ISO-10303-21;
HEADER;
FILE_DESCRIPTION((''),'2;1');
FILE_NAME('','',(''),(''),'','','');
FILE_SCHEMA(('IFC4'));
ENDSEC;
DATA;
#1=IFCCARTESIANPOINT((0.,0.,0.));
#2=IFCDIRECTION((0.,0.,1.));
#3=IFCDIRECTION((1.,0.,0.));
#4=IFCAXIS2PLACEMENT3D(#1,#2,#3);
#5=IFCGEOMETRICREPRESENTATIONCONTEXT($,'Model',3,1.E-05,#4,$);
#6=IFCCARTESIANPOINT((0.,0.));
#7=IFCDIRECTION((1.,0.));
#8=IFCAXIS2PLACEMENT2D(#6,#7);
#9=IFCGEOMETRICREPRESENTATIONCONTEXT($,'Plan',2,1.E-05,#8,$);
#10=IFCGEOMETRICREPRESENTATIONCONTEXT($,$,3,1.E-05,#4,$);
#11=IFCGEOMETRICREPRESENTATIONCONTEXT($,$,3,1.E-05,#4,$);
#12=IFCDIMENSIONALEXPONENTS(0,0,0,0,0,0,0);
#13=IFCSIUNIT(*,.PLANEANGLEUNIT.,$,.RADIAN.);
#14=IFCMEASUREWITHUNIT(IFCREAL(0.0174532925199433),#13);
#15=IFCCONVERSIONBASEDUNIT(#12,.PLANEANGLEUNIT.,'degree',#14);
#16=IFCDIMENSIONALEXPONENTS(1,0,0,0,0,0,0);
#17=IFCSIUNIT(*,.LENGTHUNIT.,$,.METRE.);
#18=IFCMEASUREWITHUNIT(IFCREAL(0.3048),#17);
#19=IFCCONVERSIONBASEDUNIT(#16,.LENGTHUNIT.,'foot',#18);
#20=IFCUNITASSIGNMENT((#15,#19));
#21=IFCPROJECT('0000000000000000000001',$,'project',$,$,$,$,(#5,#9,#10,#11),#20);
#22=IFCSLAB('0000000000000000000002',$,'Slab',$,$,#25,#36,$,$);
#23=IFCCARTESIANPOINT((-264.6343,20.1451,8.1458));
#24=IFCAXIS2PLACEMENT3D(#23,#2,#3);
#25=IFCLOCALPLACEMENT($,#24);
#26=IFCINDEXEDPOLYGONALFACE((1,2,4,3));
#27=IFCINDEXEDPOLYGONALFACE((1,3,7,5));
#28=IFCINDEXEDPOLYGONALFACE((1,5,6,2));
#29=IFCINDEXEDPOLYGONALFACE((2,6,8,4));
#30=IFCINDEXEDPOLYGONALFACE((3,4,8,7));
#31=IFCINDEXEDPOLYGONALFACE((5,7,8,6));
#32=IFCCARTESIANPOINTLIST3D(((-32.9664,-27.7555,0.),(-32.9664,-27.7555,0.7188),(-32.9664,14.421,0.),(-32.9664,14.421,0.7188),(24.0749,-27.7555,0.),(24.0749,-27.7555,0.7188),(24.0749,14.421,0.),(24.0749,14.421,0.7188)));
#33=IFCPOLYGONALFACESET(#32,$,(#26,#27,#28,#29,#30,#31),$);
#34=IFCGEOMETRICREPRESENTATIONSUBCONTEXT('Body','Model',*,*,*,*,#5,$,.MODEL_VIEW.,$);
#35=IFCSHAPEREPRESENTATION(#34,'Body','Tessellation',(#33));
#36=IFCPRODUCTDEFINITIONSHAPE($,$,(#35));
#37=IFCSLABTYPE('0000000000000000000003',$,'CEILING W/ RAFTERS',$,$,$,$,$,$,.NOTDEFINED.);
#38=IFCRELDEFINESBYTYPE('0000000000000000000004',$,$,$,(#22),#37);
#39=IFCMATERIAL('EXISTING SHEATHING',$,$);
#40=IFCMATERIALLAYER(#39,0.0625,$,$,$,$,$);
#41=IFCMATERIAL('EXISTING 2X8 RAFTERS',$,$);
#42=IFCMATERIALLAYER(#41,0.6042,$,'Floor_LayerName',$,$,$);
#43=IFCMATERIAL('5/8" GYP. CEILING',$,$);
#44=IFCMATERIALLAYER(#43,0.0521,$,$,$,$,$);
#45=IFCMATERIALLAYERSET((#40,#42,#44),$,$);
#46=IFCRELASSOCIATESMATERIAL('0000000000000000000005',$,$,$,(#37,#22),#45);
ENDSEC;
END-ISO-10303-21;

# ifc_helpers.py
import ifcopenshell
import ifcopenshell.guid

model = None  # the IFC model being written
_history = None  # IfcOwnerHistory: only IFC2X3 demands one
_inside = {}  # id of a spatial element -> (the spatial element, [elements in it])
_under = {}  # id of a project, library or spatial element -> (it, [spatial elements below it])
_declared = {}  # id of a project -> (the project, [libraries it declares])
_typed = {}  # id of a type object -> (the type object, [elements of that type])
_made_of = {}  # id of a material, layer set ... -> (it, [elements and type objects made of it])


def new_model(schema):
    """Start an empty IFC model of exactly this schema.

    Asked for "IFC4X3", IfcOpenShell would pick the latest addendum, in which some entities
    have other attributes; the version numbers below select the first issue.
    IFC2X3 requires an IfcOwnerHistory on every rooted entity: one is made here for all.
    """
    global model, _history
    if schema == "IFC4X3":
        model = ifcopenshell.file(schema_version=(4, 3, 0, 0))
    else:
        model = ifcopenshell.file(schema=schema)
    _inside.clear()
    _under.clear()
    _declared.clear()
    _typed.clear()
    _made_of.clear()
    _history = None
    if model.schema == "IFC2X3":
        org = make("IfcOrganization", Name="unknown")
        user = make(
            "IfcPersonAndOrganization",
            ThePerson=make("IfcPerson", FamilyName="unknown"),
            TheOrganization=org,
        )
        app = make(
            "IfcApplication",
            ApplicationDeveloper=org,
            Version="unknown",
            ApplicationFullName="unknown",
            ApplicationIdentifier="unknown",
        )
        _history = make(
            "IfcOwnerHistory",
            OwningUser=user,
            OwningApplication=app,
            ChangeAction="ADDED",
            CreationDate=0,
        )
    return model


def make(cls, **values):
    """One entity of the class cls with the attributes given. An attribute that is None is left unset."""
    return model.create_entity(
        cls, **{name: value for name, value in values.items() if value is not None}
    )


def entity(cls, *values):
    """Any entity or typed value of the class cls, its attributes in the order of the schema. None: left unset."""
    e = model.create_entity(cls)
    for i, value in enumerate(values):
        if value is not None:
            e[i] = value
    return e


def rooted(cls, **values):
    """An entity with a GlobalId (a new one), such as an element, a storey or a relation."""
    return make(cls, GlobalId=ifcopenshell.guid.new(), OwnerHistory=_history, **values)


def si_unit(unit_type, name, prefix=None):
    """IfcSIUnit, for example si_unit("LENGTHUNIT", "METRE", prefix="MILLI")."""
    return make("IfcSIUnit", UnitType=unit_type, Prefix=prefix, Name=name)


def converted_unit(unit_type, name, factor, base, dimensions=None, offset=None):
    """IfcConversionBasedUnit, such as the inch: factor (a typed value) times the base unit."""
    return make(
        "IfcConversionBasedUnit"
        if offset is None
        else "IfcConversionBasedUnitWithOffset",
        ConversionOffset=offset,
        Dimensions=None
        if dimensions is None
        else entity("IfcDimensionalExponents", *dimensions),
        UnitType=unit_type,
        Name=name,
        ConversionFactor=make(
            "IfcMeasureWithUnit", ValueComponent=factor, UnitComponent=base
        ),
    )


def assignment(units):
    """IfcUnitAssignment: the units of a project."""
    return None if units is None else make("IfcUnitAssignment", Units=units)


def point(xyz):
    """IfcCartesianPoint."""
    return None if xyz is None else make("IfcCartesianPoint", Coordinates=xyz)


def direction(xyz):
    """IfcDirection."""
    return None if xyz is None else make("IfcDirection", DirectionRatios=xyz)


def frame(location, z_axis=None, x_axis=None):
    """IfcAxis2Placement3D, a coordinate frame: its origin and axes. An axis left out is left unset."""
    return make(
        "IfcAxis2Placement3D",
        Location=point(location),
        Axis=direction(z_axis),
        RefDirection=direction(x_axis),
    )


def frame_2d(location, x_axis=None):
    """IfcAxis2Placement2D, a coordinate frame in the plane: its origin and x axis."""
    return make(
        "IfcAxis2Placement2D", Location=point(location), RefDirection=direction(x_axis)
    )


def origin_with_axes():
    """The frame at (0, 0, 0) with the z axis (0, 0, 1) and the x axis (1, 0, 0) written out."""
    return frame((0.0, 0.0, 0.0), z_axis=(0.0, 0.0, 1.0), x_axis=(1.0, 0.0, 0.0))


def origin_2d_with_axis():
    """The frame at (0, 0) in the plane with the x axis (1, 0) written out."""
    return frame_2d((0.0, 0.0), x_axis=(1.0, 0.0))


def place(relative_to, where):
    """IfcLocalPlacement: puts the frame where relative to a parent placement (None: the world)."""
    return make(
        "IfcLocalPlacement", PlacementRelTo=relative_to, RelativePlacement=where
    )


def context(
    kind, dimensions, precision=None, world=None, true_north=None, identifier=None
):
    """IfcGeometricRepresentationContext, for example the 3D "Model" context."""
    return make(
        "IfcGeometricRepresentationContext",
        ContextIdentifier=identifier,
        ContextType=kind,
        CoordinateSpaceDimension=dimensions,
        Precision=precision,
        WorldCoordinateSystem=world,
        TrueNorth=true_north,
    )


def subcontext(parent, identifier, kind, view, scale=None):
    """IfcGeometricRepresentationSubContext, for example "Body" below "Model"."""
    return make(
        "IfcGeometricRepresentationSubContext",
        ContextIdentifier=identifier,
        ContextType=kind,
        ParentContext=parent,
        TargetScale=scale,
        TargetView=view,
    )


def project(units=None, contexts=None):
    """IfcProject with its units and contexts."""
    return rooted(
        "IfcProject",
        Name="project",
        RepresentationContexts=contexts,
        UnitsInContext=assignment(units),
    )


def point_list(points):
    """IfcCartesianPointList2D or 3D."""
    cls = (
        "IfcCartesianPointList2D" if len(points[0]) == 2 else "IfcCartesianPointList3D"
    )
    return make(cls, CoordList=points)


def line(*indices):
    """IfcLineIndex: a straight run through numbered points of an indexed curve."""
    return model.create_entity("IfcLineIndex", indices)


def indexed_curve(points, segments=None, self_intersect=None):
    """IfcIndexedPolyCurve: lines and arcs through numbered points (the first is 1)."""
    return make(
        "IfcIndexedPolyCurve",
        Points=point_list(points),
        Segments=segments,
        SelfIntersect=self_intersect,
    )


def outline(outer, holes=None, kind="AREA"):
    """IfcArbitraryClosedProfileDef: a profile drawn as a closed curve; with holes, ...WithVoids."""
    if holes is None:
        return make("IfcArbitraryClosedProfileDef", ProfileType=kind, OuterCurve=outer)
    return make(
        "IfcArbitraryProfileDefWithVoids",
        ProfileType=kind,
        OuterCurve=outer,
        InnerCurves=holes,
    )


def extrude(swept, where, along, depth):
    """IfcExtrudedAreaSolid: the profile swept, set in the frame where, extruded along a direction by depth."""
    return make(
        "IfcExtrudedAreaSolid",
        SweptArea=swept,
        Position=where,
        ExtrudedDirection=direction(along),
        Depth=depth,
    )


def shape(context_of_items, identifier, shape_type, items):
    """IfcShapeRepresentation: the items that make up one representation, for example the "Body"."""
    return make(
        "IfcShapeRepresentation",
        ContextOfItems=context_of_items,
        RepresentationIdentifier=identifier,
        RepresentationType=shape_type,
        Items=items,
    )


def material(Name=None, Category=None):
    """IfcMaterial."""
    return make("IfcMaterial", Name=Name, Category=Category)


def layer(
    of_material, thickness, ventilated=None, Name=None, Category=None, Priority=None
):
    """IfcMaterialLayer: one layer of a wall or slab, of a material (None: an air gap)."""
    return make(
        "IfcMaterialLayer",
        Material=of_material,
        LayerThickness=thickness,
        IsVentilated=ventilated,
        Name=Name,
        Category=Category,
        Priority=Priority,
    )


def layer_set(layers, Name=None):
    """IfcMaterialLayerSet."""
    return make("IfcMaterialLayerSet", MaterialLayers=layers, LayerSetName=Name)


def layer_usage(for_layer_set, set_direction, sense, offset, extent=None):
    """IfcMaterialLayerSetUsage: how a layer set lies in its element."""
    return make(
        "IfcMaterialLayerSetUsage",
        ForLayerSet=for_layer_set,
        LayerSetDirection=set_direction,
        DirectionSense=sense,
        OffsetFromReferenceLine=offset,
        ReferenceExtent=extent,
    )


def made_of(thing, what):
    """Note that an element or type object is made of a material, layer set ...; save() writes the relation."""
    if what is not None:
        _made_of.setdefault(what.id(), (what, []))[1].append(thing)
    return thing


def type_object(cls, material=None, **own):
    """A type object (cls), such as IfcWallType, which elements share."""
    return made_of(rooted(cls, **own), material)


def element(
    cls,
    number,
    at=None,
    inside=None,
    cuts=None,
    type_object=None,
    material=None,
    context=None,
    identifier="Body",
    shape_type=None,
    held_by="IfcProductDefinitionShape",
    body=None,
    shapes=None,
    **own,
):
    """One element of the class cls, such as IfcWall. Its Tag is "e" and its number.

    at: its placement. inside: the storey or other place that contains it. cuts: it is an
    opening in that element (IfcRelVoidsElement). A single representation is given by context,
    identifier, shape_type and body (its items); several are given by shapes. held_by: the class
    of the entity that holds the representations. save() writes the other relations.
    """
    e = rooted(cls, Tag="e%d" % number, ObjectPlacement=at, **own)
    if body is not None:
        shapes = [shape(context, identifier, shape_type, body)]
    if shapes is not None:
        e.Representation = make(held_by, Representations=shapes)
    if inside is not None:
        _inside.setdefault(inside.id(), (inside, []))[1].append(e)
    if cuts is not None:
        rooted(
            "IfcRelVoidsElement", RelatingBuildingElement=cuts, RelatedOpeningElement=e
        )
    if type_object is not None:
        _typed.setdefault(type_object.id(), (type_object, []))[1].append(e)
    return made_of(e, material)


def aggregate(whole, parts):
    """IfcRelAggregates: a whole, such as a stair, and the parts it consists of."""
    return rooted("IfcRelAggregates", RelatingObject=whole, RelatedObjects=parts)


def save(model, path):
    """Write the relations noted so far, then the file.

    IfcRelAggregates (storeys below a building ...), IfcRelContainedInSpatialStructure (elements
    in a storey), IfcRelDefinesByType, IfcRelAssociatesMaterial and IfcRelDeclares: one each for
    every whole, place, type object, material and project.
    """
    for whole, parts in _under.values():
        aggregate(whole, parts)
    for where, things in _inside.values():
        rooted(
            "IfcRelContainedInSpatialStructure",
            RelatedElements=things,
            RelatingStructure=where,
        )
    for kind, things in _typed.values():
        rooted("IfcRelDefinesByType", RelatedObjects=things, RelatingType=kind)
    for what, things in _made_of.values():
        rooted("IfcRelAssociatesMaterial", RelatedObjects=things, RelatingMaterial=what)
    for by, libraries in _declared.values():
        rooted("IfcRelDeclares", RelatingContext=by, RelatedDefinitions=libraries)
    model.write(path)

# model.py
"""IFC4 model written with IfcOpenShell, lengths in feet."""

from ifc_helpers import new_model, entity, si_unit, converted_unit, frame, origin_with_axes, origin_2d_with_axis, place, context, subcontext, project, line, indexed_curve, outline, extrude, material, layer, layer_set, layer_usage, type_object, element, save


model = new_model("IFC4")

# Units and contexts
model_context = context("Model", 3, precision=1e-05, world=origin_with_axes())
plan_context = context("Plan", 2, precision=1e-05, world=origin_2d_with_axis())
context_of_model_1 = context(None, 3, precision=1e-05, world=origin_with_axes())
context_of_model_2 = context(None, 3, precision=1e-05, world=origin_with_axes())
body_context = subcontext(model_context, "Body", "Model", "MODEL_VIEW")
ifc_project = project(units=[converted_unit("PLANEANGLEUNIT", "degree", entity("IfcReal", 0.0174532925199433), si_unit("PLANEANGLEUNIT", "RADIAN"), dimensions=[0, 0, 0, 0, 0, 0, 0]), converted_unit("LENGTHUNIT", "foot", entity("IfcReal", 0.3048), si_unit("LENGTHUNIT", "METRE"), dimensions=[1, 0, 0, 0, 0, 0, 0])], contexts=[model_context, plan_context, context_of_model_1, context_of_model_2])

# Slab
ifc_material_1 = material(Name="EXISTING SHEATHING")
ifc_layer_1 = layer(ifc_material_1, 0.0625)
ifc_material_2 = material(Name="EXISTING 2X8 RAFTERS")
ifc_layer_2 = layer(ifc_material_2, 0.6042, Name="Floor_LayerName")
ifc_material_3 = material(Name="5/8\" GYP. CEILING")
ifc_layer_3 = layer(ifc_material_3, 0.0521)
ifc_layer_set = layer_set([ifc_layer_1, ifc_layer_2, ifc_layer_3])
ifc_layer_usage = layer_usage(ifc_layer_set, "AXIS3", "POSITIVE", 0.0)
slab_type = type_object("IfcSlabType", Name="CEILING W/ RAFTERS", PredefinedType="NOTDEFINED", material=ifc_layer_set)
slab_placement = place(None, frame((-264.6343, 20.1451, 8.1458), z_axis=(0.0, 0.0, 1.0), x_axis=(1.0, 0.0, 0.0)))
element("IfcSlab", 1, at=slab_placement, type_object=slab_type, material=ifc_layer_usage, Name="Slab", context=body_context, shape_type="SweptSolid", body=[
    extrude(outline(indexed_curve([(-32.9664, 14.421), (-32.9664, -27.7555), (24.0749, -27.7555), (24.0749, 14.421)], segments=[line(4, 1), line(1, 2), line(2, 3), line(3, 4)], self_intersect=False)), None, (0.0, 0.0, 1.0), 0.7188),
])

save(model, "model.ifc")
